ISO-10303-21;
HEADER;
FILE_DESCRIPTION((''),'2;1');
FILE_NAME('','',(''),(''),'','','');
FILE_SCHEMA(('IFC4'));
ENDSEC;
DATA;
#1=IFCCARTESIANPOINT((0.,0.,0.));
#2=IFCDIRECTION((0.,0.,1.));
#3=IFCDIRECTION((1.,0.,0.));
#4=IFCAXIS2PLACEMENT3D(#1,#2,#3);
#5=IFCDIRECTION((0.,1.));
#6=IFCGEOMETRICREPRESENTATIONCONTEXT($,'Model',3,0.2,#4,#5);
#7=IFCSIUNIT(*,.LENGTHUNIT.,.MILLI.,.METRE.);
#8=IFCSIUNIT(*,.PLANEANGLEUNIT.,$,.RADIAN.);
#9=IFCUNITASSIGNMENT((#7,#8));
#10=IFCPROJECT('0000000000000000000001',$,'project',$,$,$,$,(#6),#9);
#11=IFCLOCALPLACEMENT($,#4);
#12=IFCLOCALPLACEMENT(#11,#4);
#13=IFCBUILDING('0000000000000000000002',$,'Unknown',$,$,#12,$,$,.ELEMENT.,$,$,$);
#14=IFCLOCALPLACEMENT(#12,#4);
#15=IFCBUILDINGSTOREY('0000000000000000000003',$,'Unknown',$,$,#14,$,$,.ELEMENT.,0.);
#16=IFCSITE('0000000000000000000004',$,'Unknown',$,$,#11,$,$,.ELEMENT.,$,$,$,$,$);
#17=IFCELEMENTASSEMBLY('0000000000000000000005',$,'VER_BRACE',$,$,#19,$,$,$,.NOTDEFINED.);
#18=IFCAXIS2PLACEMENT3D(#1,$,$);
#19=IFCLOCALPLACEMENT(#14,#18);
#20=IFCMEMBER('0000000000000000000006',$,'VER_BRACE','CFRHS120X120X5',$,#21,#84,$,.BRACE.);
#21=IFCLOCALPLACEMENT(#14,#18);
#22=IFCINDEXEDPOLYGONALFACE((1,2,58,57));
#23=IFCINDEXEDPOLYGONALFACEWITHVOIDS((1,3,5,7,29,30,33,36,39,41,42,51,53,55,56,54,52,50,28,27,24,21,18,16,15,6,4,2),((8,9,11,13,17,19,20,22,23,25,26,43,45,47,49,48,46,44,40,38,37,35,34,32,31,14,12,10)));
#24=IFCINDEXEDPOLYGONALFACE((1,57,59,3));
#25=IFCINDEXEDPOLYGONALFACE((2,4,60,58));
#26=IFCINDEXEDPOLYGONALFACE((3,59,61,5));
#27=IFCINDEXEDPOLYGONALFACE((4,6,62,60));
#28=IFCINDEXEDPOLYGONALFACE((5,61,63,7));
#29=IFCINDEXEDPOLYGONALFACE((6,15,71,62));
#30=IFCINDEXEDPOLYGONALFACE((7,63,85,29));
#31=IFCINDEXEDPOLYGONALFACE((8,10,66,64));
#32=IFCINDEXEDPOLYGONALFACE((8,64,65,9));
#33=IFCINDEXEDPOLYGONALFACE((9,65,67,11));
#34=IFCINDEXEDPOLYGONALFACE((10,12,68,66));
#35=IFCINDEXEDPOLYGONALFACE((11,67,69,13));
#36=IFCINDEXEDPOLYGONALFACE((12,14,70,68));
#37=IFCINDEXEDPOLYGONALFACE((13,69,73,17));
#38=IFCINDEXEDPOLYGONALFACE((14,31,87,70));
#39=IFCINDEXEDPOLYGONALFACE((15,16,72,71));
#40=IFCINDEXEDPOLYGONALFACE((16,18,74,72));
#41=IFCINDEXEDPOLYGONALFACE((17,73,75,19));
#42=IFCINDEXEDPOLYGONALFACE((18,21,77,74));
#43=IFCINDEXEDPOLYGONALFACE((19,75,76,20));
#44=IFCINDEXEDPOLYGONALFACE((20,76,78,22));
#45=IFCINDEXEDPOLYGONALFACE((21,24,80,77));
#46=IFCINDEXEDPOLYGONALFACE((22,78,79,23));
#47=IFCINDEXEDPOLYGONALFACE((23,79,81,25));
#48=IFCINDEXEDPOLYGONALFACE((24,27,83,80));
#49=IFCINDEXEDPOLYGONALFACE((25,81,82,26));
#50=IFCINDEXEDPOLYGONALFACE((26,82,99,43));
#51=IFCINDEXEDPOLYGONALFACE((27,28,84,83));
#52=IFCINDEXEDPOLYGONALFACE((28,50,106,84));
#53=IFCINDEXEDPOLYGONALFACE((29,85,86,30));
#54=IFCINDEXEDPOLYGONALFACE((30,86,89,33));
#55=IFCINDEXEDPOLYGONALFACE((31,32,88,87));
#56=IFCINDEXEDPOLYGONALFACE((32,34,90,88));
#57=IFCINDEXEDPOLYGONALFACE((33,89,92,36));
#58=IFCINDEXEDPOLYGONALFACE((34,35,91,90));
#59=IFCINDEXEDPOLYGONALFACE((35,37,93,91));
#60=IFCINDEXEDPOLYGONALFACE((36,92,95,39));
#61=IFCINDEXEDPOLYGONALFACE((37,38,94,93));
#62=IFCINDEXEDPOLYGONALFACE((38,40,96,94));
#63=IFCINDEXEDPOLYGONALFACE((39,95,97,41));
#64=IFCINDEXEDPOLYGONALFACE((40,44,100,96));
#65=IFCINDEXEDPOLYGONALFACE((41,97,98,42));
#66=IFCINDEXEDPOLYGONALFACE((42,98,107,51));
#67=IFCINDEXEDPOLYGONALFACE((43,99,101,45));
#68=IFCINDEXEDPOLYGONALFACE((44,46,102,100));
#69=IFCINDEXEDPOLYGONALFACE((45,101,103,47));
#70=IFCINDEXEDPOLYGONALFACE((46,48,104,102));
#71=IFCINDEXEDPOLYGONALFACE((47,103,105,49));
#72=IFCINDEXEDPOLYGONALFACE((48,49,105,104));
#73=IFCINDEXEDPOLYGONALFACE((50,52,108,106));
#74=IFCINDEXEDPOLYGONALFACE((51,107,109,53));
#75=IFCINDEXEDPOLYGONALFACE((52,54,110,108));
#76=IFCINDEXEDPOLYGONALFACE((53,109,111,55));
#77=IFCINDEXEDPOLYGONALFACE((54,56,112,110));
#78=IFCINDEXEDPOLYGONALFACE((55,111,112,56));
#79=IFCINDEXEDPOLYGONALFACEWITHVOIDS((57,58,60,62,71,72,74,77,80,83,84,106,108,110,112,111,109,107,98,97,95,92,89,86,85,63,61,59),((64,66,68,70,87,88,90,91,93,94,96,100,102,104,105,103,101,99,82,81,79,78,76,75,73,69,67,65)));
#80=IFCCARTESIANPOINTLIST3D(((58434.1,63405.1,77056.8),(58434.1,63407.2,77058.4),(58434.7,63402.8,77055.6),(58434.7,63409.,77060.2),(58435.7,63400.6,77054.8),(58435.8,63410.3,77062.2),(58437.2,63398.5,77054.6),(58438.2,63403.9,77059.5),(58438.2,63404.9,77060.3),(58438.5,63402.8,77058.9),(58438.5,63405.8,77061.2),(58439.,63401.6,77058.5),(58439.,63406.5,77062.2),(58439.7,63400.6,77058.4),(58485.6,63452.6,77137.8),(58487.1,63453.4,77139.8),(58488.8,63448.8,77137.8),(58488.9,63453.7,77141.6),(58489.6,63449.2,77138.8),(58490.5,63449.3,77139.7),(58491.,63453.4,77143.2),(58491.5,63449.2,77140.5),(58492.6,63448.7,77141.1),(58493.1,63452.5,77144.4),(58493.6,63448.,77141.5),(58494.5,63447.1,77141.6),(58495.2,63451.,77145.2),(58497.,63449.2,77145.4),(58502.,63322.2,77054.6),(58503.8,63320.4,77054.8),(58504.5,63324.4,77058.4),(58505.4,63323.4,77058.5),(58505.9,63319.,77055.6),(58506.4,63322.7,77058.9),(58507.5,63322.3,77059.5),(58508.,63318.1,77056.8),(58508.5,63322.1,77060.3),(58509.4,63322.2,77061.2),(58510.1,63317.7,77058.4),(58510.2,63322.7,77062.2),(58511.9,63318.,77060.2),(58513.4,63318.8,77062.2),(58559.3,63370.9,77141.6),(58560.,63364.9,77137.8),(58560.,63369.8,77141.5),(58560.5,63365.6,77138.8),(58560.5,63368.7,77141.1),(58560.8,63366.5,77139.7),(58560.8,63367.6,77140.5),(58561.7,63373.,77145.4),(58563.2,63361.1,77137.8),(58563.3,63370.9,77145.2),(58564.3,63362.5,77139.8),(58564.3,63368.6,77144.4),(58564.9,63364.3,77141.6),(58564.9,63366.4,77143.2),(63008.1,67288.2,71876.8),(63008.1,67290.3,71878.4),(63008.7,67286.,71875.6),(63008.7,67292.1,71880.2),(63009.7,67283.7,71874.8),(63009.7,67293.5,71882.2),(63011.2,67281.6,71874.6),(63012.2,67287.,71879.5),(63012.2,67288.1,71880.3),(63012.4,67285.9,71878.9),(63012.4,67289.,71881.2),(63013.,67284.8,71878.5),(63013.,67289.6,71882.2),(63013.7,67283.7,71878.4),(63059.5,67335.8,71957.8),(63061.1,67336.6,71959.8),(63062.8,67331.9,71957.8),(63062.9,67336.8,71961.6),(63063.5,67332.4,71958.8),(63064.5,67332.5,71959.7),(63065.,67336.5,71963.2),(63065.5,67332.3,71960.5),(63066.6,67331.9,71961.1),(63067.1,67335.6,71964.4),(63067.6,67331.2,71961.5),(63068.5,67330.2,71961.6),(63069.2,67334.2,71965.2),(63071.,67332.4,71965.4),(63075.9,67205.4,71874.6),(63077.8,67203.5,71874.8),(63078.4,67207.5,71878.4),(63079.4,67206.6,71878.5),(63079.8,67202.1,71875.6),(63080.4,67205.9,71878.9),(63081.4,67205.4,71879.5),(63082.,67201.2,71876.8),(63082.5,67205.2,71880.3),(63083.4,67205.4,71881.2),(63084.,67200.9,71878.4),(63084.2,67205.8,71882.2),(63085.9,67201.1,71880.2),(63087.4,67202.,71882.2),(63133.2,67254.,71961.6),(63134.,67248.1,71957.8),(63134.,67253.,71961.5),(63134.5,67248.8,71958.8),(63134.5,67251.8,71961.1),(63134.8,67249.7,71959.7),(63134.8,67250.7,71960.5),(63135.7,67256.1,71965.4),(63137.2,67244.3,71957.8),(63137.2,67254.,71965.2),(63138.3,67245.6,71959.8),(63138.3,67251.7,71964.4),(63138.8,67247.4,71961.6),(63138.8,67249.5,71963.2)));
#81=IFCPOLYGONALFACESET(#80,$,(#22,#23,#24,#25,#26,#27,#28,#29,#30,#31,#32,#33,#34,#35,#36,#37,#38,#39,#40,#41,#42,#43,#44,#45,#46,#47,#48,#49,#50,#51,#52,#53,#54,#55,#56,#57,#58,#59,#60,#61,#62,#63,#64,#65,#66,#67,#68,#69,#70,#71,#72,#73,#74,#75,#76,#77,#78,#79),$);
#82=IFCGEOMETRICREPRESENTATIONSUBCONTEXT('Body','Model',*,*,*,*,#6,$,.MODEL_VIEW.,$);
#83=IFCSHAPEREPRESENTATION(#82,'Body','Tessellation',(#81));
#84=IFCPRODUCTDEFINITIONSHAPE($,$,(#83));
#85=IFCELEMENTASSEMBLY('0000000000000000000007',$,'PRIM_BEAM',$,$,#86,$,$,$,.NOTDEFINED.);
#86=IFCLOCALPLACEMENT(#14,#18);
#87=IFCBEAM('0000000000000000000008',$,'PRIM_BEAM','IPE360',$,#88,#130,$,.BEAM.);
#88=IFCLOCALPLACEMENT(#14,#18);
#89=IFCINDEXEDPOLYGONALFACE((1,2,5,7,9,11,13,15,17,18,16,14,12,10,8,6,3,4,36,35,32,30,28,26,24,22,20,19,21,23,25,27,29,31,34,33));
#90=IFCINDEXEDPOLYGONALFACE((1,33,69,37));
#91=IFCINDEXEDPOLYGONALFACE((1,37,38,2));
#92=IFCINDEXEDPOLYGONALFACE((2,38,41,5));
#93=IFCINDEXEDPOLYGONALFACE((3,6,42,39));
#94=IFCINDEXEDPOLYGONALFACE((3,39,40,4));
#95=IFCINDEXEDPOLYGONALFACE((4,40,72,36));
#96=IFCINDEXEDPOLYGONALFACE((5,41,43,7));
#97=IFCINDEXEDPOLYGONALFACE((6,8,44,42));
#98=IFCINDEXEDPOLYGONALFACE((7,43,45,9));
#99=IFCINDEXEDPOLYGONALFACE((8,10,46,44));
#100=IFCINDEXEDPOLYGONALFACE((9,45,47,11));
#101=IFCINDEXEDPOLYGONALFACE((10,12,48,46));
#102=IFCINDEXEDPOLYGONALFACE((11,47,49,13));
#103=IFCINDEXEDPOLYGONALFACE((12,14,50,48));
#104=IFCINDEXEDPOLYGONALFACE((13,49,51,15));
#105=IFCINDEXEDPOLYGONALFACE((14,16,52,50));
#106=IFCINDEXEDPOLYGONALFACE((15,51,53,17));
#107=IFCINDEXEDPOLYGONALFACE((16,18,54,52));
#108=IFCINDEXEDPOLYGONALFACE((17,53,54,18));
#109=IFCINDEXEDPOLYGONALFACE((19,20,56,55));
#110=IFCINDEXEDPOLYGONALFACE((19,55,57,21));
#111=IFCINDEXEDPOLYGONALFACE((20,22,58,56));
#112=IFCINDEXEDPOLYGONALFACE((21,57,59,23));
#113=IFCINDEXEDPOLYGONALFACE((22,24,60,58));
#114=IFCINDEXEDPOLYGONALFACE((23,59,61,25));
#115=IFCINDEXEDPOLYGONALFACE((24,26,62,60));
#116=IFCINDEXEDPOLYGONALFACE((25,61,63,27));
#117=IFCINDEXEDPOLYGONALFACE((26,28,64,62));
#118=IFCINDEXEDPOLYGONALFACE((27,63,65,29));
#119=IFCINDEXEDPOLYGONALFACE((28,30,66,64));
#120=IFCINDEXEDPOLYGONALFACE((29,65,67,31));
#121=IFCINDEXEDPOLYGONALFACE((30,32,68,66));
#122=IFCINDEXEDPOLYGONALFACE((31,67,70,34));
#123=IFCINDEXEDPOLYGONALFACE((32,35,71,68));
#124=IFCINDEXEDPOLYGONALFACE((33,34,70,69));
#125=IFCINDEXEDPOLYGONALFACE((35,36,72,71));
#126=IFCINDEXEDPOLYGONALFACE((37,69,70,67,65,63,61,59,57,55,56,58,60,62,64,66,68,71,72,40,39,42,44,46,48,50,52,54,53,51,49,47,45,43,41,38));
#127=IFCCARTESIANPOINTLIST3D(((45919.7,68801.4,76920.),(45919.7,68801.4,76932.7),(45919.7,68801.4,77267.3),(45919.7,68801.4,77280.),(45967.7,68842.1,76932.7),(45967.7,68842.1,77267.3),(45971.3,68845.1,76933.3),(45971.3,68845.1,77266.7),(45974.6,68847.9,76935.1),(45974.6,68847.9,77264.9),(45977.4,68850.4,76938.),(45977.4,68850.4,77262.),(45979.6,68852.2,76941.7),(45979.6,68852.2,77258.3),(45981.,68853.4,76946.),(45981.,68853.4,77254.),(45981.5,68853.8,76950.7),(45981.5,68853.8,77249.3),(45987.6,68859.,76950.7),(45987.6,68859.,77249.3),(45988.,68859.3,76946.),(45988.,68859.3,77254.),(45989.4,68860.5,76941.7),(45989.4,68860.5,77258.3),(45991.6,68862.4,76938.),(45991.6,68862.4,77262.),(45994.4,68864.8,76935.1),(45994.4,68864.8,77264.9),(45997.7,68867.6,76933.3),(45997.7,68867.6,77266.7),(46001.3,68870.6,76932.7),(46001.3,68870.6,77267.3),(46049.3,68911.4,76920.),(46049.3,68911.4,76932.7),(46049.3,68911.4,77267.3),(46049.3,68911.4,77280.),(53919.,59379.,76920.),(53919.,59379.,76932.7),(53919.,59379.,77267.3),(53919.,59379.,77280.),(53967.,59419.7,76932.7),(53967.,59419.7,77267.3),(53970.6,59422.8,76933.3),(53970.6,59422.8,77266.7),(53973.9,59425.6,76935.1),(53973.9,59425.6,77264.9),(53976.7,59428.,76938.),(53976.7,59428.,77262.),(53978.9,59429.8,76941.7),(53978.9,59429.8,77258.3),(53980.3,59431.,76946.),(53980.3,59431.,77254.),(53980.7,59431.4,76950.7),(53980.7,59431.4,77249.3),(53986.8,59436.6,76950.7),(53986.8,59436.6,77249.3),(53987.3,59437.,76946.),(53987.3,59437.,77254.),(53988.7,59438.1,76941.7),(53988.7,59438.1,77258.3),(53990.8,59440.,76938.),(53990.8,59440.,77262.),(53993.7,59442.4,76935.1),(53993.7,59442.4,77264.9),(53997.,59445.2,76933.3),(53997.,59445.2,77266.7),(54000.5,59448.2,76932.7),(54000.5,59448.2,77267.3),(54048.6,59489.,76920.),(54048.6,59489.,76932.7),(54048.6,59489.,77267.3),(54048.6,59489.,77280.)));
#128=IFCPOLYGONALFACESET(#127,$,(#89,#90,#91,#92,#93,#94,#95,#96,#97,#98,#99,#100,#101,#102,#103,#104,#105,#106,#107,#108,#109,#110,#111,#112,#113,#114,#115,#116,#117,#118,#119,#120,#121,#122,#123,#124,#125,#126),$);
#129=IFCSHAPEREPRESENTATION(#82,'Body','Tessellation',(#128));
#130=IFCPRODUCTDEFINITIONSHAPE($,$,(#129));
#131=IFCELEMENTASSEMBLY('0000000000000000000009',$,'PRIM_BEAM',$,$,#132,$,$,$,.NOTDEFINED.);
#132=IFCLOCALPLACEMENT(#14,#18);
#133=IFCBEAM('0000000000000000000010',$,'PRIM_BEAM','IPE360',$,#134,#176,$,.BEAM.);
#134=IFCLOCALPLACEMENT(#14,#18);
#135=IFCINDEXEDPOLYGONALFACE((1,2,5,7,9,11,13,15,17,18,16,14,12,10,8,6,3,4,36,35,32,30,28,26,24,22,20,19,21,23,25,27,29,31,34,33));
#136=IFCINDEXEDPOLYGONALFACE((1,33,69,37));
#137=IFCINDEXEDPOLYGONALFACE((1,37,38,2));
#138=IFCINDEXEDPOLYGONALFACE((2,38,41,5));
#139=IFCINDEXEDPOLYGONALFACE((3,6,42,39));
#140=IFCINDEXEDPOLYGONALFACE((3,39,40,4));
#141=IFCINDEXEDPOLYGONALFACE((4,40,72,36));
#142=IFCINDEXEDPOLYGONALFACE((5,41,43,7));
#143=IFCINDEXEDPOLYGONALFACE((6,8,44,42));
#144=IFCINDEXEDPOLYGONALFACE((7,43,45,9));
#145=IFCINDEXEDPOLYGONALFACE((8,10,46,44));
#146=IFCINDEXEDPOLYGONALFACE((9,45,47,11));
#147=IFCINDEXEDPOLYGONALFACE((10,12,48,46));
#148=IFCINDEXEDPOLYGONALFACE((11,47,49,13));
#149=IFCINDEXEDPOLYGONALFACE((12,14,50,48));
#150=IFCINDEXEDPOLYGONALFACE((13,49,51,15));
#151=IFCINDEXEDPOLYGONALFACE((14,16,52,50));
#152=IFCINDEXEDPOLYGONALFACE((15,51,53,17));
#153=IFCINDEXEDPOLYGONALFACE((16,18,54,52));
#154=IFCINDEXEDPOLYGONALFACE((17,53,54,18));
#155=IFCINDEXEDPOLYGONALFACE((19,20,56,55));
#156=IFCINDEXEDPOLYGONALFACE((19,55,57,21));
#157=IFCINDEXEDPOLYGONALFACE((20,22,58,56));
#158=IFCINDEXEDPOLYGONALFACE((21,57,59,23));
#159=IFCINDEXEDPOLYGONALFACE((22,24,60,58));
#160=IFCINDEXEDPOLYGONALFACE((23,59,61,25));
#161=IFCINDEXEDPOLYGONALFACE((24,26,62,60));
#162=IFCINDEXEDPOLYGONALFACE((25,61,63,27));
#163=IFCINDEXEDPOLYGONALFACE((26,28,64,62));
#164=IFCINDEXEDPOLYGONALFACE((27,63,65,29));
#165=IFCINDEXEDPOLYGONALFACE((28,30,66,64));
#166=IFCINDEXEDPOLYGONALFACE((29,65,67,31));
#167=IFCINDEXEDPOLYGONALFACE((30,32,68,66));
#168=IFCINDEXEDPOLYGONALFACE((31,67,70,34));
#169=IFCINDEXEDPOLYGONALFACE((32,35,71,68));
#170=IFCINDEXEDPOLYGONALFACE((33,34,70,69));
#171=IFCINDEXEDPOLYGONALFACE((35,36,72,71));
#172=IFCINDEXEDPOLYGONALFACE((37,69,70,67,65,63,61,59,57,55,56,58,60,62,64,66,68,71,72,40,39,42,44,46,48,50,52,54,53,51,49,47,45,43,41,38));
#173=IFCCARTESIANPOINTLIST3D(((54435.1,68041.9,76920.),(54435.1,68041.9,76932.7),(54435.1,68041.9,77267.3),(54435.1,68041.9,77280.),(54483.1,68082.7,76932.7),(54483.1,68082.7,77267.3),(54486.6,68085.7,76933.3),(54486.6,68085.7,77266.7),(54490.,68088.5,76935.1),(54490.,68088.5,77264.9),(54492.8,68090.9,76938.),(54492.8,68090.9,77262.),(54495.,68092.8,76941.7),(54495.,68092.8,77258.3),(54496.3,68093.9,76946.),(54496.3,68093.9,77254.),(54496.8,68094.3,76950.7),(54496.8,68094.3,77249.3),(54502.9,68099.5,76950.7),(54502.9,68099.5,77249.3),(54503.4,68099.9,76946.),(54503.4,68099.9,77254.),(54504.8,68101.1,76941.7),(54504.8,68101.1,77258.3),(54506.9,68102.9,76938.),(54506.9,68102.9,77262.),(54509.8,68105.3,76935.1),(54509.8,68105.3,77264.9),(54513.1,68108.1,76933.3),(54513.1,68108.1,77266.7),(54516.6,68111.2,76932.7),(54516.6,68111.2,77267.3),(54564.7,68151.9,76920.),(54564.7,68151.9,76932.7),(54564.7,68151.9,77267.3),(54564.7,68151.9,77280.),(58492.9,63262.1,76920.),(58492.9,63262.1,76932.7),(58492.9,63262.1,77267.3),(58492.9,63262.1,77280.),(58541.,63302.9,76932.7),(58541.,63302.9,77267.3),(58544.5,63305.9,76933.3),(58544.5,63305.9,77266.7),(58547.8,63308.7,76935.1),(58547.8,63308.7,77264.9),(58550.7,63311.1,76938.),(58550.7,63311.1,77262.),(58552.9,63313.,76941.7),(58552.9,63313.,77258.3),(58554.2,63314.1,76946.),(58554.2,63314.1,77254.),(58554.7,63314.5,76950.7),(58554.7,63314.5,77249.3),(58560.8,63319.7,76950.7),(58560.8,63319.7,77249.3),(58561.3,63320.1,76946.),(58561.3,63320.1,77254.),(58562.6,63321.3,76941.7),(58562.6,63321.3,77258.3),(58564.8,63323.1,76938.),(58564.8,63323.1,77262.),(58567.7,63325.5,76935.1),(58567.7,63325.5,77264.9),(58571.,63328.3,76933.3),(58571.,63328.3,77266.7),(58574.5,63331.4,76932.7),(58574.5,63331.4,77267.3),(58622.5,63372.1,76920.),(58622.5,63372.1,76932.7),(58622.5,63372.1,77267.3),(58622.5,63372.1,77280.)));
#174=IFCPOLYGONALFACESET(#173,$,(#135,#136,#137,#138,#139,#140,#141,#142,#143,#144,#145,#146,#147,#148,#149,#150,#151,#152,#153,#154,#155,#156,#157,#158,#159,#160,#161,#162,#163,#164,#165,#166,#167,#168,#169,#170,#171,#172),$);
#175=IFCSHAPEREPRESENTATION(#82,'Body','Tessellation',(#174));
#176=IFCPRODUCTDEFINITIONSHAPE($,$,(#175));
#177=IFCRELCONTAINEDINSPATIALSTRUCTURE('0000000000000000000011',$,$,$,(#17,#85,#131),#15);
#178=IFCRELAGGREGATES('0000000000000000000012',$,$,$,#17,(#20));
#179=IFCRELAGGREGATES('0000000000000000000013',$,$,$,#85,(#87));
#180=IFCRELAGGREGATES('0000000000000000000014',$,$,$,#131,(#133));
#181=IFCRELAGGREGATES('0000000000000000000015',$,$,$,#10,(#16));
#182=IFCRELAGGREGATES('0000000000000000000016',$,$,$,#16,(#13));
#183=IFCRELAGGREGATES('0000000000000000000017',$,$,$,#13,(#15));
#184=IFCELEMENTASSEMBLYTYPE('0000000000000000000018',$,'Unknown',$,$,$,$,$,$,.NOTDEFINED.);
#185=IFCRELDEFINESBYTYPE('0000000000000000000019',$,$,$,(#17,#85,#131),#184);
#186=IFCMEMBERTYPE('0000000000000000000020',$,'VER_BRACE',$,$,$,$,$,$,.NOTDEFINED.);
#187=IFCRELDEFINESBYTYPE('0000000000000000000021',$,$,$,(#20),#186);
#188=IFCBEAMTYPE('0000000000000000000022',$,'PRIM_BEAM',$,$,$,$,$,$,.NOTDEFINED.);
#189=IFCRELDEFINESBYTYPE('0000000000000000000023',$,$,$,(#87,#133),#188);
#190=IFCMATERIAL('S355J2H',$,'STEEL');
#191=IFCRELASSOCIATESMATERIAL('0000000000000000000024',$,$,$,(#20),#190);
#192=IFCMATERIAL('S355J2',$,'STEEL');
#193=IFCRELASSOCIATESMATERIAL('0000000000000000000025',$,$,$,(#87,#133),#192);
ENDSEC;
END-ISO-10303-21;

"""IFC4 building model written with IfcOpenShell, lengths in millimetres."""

from ifc_helpers import new_model, si_unit, direction, frame, origin_with_axes, origin_2d_with_axis, place, context, subcontext, project, spatial, hollow_rectangle, i_section, extrude, material, material_profile, profile_set, profile_usage, type_object, element, aggregate, save


model = new_model("IFC4")

# Units and contexts
model_context = context("Model", 3, precision=0.2, world=origin_with_axes(), true_north=direction((0.0, 1.0)))
body_context = subcontext(model_context, "Body", "Model", "MODEL_VIEW")
ifc_project = project(units=[si_unit("LENGTHUNIT", "METRE", prefix="MILLI"), si_unit("PLANEANGLEUNIT", "RADIAN")], contexts=[model_context])

# Site, building, storey
site_placement = place(None, origin_with_axes())
site = spatial("IfcSite", under=ifc_project, at=site_placement, Name="Unknown", CompositionType="ELEMENT")
building_placement = place(site_placement, origin_with_axes())
building = spatial("IfcBuilding", under=site, at=building_placement, Name="Unknown", CompositionType="ELEMENT")
storey_placement = place(building_placement, origin_with_axes())
storey = spatial("IfcBuildingStorey", under=building, at=storey_placement, Name="Unknown", CompositionType="ELEMENT", Elevation=0.0)

# Shared definitions
element_assembly_type = type_object("IfcElementAssemblyType", Name="Unknown", PredefinedType="NOTDEFINED")
ifc_material_1 = material(Name="S355J2", Category="STEEL")

# Element assembly, member
assembly_1_placement = place(storey_placement, frame((58499.5, 63385.7, 77100.0), z_axis=(0.64719, -0.762329, 0.0), x_axis=(0.577034, 0.489882, -0.653488)))
assembly_1 = element("IfcElementAssembly", 1, at=assembly_1_placement, inside=storey, type_object=element_assembly_type, Name="VER_BRACE", PredefinedType="NOTDEFINED")
ifc_material_2 = material(Name="S355J2H", Category="STEEL")
ifc_material_profile_1 = material_profile(ifc_material_2, hollow_rectangle(XDim=120.0, YDim=120.0, WallThickness=5.0, InnerFilletRadius=5.0, OuterFilletRadius=10.0, at=origin_2d_with_axis()), Name="CFRHS120X120X5")
ifc_profile_set_1 = profile_set([ifc_material_profile_1])
ifc_profile_usage_1 = profile_usage(ifc_profile_set_1, cardinal=5)
member_type = type_object("IfcMemberType", Name="VER_BRACE")
member_placement = place(assembly_1_placement, origin_with_axes())
member = element("IfcMember", 2, at=member_placement, type_object=member_type, material=ifc_profile_usage_1, Name="VER_BRACE", Description="CFRHS120X120X5", PredefinedType="BRACE", context=body_context, shape_type="SolidModel", body=[
    extrude(hollow_rectangle(XDim=120.0, YDim=120.0, WallThickness=5.0, InnerFilletRadius=5.0, OuterFilletRadius=10.0, at=origin_2d_with_axis()), frame((0.0, 0.0, 0.0), z_axis=(-1.0, 0.0, 0.0), x_axis=(0.0, 0.0, 1.0)), (0.0, 0.0, -1.0), 7926.7),
])
aggregate(assembly_1, [member])

# Element assemblies, beams
assembly_2_placement = place(storey_placement, frame((53983.8, 59434.0, 77100.0), z_axis=(0.762329, 0.64719, 0.0), x_axis=(-0.64719, 0.762329, 0.0)))
assembly_2 = element("IfcElementAssembly", 3, at=assembly_2_placement, inside=storey, type_object=element_assembly_type, Name="PRIM_BEAM", PredefinedType="NOTDEFINED")
ifc_material_profile_2 = material_profile(ifc_material_1, i_section(OverallWidth=170.0, OverallDepth=360.0, WebThickness=8.0, FlangeThickness=12.7, FilletRadius=18.0, FlangeEdgeRadius=0.0, FlangeSlope=0.0, at=origin_2d_with_axis()), Name="IPE360")
ifc_profile_set_2 = profile_set([ifc_material_profile_2])
ifc_profile_usage_2 = profile_usage(ifc_profile_set_2, cardinal=2)
beam_type_1 = type_object("IfcBeamType", Name="PRIM_BEAM")
beam_1_placement = place(assembly_2_placement, origin_with_axes())
beam_1 = element("IfcBeam", 4, at=beam_1_placement, type_object=beam_type_1, material=ifc_profile_usage_2, Name="PRIM_BEAM", Description="IPE360", PredefinedType="BEAM", context=body_context, shape_type="SolidModel", body=[
    extrude(i_section(OverallWidth=170.0, OverallDepth=360.0, WebThickness=8.0, FlangeThickness=12.7, FilletRadius=18.0, FlangeEdgeRadius=0.0, FlangeSlope=0.0, at=origin_2d_with_axis()), frame((0.0, 0.0, 0.0), z_axis=(-1.0, 0.0, 0.0), x_axis=(0.0, 0.0, 1.0)), (0.0, 0.0, -1.0), 12360.0),
])
aggregate(assembly_2, [beam_1])
assembly_3_placement = place(storey_placement, frame((58557.7, 63317.1, 77100.0), z_axis=(0.762329, 0.64719, 0.0), x_axis=(-0.64719, 0.762329, 0.0)))
assembly_3 = element("IfcElementAssembly", 5, at=assembly_3_placement, inside=storey, type_object=element_assembly_type, Name="PRIM_BEAM", PredefinedType="NOTDEFINED")
beam_2_placement = place(assembly_3_placement, origin_with_axes())
beam_2 = element("IfcBeam", 6, at=beam_2_placement, type_object=beam_type_1, material=ifc_profile_usage_2, Name="PRIM_BEAM", Description="IPE360", PredefinedType="BEAM", context=body_context, shape_type="SolidModel", body=[
    extrude(i_section(OverallWidth=170.0, OverallDepth=360.0, WebThickness=8.0, FlangeThickness=12.7, FilletRadius=18.0, FlangeEdgeRadius=0.0, FlangeSlope=0.0, at=origin_2d_with_axis()), frame((0.0, 0.0, 0.0), z_axis=(-1.0, 0.0, 0.0), x_axis=(0.0, 0.0, 1.0)), (0.0, 0.0, -1.0), 6270.0),
])
aggregate(assembly_3, [beam_2])

save(model, "model.ifc")
